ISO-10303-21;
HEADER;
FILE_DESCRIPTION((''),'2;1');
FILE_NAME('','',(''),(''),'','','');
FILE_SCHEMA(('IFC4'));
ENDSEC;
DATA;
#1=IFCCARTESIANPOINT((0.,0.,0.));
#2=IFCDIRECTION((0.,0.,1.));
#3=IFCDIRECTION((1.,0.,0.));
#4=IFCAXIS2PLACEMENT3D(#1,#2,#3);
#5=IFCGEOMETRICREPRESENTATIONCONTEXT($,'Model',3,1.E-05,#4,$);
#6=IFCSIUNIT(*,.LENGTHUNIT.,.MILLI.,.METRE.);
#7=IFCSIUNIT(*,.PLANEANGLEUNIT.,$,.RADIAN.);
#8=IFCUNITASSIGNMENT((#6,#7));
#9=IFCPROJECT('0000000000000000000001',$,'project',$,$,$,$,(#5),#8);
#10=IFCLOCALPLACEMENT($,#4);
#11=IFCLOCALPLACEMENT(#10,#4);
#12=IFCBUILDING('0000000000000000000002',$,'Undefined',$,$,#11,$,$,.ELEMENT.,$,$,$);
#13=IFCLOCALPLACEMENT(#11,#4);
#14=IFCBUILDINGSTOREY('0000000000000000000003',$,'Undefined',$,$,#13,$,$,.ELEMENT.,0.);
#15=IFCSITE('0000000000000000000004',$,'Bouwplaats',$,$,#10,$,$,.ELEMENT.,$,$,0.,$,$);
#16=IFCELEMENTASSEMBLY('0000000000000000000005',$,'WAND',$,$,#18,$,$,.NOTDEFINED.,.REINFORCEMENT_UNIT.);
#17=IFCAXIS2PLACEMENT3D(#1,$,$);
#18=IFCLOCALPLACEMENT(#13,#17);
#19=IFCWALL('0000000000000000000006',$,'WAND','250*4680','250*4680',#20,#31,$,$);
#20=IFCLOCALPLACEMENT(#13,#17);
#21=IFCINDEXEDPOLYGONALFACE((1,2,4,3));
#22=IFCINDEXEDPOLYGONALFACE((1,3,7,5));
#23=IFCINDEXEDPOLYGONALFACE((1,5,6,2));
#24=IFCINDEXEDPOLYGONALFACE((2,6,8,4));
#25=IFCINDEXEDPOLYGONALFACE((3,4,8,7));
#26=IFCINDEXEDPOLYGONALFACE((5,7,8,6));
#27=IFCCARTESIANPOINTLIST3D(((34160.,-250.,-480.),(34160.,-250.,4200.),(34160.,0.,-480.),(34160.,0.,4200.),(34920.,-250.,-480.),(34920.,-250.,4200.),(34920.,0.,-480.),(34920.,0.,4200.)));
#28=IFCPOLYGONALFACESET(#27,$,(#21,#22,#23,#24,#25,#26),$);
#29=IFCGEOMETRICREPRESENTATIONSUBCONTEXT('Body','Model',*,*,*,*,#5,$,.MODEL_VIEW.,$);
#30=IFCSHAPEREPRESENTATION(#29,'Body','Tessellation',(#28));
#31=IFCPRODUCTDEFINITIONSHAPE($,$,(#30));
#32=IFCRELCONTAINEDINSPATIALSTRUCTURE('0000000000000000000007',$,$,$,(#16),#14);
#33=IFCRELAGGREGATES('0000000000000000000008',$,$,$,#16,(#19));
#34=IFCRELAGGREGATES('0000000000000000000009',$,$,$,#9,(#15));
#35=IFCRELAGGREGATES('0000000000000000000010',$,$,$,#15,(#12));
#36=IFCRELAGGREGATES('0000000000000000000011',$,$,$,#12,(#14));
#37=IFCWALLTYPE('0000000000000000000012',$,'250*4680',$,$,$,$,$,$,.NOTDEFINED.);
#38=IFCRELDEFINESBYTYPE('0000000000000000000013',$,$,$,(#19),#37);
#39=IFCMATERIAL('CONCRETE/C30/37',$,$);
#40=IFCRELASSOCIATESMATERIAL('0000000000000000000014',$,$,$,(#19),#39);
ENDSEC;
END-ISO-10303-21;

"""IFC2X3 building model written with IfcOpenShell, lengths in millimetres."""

from ifc_helpers import new_model, si_unit, frame, frame_2d, origin_with_axes, place, context, subcontext, project, spatial, rectangle, extrude, material, type_object, element, aggregate, save


model = new_model("IFC2X3")

# Units and contexts
model_context = context("Model", 3, precision=1e-05, world=origin_with_axes())
body_context = subcontext(model_context, "Body", "Model", "MODEL_VIEW")
ifc_project = project(units=[si_unit("LENGTHUNIT", "METRE", prefix="MILLI"), si_unit("PLANEANGLEUNIT", "RADIAN")], contexts=[model_context])

# Site, building, storey
site_placement = place(None, origin_with_axes())
site = spatial("IfcSite", under=ifc_project, at=site_placement, Name="Bouwplaats", CompositionType="ELEMENT", RefElevation=0.0)
building_placement = place(site_placement, origin_with_axes())
building = spatial("IfcBuilding", under=site, at=building_placement, Name="Undefined", CompositionType="ELEMENT")
storey_placement = place(building_placement, origin_with_axes())
storey = spatial("IfcBuildingStorey", under=building, at=storey_placement, Name="Undefined", CompositionType="ELEMENT", Elevation=0.0)

# Shared definitions
ifc_material_1 = material(Name="CONCRETE/C30/37")

# Element assembly, wall
wall_type = type_object("IfcWallType", Name="250*4680", PredefinedType="NOTDEFINED")
assembly_1_placement = place(storey_placement, origin_with_axes())
assembly_1 = element("IfcElementAssembly", 1, at=assembly_1_placement, inside=storey, Name="WAND", AssemblyPlace="NOTDEFINED", PredefinedType="REINFORCEMENT_UNIT")
wall_1_placement = place(assembly_1_placement, frame((34160.0, -125.0, -480.0), z_axis=(0.0, 0.0, 1.0), x_axis=(1.0, 0.0, 0.0)))
wall_1 = element("IfcWall", 2, at=wall_1_placement, type_object=wall_type, material=ifc_material_1, Name="WAND", Description="250*4680", ObjectType="250*4680", context=body_context, shape_type="SweptSolid", body=[
    extrude(rectangle(XDim=760.0, YDim=250.0, at=frame_2d((0.0, 380.0), x_axis=(0.0, -1.0))), frame((0.0, 0.0, 0.0), z_axis=(0.0, 0.0, 1.0), x_axis=(0.0, -1.0, 0.0)), (0.0, 0.0, 1.0), 4680.0),
])
aggregate(assembly_1, [wall_1])

save(model, "model.ifc")
